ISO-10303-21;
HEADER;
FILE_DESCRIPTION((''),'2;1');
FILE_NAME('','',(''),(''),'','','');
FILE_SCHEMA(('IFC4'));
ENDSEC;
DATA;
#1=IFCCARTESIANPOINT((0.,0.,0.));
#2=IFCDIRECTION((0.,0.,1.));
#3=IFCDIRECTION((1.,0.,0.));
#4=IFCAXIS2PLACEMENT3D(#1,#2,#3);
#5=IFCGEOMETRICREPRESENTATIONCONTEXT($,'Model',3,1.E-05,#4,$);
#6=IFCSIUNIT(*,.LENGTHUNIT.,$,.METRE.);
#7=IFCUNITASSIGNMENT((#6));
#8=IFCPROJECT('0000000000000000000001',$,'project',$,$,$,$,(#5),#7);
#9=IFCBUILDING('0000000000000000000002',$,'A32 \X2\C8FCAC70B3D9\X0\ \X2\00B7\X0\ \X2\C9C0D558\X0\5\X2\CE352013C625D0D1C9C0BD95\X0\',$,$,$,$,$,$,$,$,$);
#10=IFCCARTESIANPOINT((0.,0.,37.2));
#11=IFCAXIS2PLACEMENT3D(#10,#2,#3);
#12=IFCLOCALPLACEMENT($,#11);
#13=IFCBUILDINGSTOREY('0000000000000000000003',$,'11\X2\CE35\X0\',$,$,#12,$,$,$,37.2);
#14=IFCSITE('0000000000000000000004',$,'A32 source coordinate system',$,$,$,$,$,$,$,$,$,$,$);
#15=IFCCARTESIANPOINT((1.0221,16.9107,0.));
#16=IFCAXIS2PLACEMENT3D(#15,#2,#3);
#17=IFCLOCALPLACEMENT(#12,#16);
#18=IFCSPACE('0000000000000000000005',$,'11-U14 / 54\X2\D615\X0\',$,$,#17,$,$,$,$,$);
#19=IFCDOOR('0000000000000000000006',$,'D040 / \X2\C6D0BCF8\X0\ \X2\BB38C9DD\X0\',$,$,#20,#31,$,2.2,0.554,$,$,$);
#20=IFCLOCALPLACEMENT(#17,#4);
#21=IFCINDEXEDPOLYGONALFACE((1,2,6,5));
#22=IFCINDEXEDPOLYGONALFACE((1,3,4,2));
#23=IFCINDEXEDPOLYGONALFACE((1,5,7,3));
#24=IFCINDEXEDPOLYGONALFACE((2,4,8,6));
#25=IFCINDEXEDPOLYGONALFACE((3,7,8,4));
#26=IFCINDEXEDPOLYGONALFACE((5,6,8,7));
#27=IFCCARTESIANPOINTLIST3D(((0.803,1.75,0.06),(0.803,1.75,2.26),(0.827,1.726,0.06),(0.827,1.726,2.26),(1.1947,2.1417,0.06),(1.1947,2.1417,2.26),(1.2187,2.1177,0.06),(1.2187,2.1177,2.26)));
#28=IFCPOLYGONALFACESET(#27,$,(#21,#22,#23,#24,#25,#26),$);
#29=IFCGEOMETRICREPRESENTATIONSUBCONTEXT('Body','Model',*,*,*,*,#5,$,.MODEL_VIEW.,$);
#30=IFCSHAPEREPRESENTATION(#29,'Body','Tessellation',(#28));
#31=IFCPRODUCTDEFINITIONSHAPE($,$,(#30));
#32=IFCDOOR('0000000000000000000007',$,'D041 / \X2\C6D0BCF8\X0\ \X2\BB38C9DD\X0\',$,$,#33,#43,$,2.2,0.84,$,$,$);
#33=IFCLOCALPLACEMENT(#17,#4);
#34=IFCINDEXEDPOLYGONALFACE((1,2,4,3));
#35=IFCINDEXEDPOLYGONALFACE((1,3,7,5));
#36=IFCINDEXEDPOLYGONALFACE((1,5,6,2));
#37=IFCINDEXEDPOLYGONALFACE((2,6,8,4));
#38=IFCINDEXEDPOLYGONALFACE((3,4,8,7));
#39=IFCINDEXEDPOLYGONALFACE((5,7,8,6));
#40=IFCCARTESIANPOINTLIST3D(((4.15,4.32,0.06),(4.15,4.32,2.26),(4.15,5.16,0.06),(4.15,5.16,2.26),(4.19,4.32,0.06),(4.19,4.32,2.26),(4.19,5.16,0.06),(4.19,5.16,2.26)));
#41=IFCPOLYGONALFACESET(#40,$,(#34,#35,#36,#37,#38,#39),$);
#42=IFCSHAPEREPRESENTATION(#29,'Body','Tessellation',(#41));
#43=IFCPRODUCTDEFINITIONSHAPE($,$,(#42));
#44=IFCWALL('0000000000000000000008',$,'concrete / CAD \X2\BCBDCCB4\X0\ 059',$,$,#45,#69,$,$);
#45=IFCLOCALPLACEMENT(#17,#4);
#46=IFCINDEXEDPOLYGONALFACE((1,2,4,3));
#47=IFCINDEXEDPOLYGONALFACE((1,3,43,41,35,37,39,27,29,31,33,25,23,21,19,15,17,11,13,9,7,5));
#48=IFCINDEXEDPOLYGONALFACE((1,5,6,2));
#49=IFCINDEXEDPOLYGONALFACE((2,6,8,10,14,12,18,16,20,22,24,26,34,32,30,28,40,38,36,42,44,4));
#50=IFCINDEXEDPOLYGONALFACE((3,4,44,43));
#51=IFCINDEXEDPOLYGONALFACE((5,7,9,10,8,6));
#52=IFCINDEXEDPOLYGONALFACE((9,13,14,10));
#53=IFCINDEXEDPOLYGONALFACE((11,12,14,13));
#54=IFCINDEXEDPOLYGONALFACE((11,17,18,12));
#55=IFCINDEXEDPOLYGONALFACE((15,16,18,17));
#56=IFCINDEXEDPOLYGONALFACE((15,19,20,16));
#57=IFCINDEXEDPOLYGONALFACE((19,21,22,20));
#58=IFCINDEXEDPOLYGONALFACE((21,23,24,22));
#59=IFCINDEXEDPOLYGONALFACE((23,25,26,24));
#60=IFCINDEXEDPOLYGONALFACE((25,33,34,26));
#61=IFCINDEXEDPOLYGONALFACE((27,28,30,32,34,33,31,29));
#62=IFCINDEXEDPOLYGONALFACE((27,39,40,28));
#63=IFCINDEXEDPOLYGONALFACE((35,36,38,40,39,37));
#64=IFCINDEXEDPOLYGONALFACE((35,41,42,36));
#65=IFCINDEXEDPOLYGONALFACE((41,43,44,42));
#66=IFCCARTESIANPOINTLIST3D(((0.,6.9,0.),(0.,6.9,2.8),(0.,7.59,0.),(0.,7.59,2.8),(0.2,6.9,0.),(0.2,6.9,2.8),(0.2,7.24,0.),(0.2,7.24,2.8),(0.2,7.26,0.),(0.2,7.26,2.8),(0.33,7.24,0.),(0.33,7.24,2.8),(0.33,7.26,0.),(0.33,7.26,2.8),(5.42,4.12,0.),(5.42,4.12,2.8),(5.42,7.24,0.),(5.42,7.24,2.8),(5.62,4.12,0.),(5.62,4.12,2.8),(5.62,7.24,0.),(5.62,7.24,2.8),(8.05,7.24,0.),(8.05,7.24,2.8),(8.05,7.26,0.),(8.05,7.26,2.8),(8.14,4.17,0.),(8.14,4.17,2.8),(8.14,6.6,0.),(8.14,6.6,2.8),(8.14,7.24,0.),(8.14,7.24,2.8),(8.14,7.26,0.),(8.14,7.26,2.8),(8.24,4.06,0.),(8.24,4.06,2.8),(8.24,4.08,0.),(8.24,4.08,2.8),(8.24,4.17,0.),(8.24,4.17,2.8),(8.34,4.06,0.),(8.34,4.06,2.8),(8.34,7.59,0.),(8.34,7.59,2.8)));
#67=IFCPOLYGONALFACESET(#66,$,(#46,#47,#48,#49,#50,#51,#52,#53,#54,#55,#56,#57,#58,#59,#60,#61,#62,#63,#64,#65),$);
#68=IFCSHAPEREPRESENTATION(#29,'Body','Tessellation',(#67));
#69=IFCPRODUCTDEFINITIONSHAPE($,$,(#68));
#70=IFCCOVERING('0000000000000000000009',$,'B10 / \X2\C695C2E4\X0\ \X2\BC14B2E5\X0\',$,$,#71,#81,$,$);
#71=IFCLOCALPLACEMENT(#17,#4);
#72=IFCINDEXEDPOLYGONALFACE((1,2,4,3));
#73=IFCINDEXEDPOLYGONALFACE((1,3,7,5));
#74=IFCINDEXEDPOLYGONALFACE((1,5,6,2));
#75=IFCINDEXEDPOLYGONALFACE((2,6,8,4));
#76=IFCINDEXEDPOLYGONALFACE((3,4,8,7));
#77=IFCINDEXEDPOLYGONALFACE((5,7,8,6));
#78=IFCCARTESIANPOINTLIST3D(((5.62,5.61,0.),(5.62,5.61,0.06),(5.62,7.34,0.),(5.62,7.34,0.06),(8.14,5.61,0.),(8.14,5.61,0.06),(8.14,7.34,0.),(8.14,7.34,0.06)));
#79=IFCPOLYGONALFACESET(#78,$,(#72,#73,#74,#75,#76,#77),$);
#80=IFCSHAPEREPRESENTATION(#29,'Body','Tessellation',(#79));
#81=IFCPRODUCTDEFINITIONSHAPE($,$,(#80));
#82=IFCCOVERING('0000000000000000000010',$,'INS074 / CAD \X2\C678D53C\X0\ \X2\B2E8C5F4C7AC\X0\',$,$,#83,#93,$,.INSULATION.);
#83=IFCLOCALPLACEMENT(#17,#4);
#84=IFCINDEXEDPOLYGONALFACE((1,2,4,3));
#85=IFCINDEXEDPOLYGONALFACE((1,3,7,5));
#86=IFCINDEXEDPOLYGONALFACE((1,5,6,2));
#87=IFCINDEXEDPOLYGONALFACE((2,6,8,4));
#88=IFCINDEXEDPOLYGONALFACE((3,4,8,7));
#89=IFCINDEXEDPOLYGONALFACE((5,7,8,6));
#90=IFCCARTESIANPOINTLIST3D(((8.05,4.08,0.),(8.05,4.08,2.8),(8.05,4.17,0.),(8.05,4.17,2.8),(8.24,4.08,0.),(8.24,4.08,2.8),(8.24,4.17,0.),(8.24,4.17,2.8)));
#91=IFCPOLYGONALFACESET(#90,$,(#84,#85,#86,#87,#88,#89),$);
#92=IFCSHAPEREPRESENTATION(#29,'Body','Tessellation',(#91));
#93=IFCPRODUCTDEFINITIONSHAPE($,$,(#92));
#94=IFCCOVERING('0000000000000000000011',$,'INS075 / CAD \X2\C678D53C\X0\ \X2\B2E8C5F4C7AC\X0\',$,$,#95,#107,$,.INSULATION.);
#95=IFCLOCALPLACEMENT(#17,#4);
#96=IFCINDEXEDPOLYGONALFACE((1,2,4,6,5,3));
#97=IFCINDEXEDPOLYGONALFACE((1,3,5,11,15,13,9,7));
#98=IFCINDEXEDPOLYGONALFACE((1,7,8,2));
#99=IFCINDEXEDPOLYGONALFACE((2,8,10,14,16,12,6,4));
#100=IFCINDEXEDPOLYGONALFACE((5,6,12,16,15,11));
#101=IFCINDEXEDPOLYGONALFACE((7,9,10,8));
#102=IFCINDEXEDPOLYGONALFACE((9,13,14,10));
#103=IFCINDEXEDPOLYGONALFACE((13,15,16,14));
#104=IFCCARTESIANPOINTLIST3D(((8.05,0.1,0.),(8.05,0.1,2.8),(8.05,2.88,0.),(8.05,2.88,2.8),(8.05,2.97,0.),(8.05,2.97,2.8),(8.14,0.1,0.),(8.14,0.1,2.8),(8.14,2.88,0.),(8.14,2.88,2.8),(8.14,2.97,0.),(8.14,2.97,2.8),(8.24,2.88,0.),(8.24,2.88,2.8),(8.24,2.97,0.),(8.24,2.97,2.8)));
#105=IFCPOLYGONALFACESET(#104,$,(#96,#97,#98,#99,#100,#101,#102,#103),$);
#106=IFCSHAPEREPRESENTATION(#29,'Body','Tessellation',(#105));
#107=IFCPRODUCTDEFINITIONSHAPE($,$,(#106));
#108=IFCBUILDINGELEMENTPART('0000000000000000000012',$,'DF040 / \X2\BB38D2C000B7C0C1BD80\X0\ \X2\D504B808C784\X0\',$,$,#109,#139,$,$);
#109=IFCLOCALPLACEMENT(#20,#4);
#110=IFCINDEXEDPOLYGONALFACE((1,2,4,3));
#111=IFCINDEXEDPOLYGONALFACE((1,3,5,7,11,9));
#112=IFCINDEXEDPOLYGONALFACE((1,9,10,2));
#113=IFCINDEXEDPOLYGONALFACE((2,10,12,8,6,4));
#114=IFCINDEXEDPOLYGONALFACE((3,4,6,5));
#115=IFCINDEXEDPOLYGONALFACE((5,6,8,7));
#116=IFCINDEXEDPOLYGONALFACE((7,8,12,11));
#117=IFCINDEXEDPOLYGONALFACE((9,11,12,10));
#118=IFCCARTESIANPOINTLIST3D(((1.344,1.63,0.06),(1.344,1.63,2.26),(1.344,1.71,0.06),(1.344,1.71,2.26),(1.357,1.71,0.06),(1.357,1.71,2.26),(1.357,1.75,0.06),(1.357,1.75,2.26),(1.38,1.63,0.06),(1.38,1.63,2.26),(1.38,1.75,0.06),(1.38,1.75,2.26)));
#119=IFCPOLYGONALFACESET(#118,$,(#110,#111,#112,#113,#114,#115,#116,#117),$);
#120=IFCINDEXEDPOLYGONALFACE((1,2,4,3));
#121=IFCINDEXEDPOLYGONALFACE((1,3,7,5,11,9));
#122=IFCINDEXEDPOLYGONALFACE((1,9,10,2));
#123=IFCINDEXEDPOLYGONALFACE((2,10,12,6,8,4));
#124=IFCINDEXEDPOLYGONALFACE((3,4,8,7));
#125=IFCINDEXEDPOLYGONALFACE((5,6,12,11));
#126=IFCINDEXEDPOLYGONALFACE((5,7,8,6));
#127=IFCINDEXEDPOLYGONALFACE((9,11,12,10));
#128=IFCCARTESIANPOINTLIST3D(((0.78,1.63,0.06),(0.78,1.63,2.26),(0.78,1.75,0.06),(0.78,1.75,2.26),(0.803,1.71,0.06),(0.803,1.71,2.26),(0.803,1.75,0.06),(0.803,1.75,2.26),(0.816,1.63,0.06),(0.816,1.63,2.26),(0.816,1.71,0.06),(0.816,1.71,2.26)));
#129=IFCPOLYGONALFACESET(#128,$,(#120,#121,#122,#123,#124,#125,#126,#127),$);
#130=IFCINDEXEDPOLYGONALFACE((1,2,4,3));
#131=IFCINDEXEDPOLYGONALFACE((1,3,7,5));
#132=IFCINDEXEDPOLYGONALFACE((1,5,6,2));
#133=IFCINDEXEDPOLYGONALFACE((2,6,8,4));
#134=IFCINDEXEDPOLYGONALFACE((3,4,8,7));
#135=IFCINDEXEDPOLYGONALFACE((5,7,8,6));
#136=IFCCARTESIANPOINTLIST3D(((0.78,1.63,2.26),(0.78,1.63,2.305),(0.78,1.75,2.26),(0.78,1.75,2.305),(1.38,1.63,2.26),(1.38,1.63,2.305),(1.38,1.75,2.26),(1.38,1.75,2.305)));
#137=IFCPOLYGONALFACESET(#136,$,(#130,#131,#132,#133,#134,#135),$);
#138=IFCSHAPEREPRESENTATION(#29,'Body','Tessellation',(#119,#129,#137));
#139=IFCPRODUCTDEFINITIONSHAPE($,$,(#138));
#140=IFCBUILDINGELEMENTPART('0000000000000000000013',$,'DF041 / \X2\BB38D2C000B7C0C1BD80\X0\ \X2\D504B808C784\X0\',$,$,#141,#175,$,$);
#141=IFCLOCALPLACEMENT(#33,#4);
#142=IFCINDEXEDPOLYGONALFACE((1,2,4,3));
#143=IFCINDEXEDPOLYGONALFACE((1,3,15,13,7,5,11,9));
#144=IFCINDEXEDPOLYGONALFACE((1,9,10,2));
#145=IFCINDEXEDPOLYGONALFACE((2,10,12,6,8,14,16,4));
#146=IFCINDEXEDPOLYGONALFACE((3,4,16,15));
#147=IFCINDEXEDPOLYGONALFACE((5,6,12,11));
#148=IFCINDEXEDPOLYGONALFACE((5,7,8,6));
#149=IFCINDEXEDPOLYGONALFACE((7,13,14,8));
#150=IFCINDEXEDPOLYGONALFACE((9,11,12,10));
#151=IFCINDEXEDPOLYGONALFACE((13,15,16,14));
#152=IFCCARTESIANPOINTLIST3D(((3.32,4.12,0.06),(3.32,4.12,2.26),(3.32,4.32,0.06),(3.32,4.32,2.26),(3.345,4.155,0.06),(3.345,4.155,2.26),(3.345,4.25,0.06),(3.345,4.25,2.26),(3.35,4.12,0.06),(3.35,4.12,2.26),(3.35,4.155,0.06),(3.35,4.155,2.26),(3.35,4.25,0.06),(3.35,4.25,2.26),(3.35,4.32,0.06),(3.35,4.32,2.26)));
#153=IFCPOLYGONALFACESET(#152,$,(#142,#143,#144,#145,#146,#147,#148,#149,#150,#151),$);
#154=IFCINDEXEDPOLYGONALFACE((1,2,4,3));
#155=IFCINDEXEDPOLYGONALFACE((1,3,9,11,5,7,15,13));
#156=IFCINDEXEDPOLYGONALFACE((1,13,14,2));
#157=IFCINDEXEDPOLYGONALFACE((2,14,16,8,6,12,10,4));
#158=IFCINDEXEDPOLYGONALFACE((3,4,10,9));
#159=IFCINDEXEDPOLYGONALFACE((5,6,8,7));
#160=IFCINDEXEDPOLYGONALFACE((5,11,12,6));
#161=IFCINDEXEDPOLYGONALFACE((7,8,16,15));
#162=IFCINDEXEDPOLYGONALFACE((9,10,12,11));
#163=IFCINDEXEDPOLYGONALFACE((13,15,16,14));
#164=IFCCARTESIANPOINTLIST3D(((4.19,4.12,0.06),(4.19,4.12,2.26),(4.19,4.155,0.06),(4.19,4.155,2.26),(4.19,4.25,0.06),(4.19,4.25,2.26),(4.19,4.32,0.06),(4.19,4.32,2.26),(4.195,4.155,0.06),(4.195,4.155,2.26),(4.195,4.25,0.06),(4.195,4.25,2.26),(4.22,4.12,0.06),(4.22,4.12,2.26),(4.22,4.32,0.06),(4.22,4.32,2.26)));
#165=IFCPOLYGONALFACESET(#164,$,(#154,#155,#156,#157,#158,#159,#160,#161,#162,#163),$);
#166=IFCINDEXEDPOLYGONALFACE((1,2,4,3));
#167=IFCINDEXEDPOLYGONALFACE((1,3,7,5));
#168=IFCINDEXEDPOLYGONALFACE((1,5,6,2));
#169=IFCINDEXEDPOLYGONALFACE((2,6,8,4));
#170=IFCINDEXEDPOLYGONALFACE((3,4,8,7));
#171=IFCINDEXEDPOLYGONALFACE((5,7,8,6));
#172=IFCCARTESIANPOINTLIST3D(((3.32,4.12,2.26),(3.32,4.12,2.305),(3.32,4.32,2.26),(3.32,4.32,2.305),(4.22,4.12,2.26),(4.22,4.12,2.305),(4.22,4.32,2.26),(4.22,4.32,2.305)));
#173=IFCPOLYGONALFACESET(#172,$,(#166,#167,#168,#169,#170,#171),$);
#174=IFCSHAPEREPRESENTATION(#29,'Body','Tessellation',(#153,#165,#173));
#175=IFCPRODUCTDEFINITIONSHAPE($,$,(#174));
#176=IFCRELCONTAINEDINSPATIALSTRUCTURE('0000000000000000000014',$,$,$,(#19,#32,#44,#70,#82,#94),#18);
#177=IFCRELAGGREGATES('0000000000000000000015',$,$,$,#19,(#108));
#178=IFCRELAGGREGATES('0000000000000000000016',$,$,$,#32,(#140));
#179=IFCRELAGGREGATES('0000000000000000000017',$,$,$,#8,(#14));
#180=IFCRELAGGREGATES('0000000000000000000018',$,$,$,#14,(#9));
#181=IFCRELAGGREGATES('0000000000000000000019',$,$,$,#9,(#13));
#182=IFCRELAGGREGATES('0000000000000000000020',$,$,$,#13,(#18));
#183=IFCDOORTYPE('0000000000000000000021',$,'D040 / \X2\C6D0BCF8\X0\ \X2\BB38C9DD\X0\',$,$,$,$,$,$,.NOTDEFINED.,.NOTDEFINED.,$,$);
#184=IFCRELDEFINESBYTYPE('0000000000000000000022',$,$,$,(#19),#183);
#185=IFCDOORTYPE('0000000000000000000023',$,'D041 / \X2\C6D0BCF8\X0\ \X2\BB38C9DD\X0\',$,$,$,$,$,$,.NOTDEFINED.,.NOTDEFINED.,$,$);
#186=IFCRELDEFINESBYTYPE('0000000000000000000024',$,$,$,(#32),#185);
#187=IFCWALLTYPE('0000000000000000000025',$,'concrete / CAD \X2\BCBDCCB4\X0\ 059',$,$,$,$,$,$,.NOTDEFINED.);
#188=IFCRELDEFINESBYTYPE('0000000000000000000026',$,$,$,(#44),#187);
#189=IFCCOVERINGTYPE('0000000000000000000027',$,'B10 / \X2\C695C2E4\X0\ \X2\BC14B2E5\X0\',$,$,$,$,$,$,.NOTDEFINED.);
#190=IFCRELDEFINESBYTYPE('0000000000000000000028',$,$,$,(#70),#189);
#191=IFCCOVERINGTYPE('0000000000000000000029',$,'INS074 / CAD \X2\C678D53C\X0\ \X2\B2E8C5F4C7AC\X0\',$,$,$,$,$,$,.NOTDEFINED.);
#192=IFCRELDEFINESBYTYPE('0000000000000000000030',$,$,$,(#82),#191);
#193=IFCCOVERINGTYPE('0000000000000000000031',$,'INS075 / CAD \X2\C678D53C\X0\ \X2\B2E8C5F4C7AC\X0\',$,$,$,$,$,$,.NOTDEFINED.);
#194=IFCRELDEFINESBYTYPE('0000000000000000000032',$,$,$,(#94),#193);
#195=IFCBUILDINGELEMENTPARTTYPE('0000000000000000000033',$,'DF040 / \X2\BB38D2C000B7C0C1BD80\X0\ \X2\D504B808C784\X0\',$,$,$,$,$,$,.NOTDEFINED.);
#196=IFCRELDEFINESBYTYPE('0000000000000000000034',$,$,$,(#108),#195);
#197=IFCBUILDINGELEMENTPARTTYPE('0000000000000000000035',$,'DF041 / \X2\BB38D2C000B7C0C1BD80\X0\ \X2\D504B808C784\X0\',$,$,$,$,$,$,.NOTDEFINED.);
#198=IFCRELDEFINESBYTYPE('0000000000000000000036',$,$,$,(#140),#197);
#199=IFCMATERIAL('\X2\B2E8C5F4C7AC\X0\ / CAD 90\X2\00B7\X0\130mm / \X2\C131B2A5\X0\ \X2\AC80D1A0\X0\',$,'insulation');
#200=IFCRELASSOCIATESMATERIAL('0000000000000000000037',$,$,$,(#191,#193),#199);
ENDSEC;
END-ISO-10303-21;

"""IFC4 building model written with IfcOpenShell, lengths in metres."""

from ifc_helpers import new_model, si_unit, frame, origin, origin_with_axes, place, context, subcontext, project, spatial, polyline, outline, extrude, source, transform, mapped, material, type_object, type_shapes, element, aggregate, save


model = new_model("IFC4")

# Units and contexts
model_context = context("Model", 3, precision=1e-05, world=origin_with_axes())
body_context = subcontext(model_context, "Body", "Model", "MODEL_VIEW")
ifc_project = project(units=[si_unit("LENGTHUNIT", "METRE")], contexts=[model_context])

# Site, building, storey, space
storey_placement = place(None, frame((0.0, 0.0, 37.2), z_axis=(0.0, 0.0, 1.0), x_axis=(1.0, 0.0, 0.0)))
space_1_placement = place(storey_placement, frame((1.0221, 16.9107, 0.0), z_axis=(0.0, 0.0, 1.0), x_axis=(1.0, 0.0, 0.0)))
site = spatial("IfcSite", under=ifc_project, Name="A32 source coordinate system")
building = spatial("IfcBuilding", under=site, Name="A32 주거동 · 지하5층–옥탑지붕")
storey = spatial("IfcBuildingStorey", under=building, at=storey_placement, Name="11층", Elevation=37.2)
space_1 = spatial("IfcSpace", under=storey, at=space_1_placement, Name="11-U14 / 54형")

# Doors
door_type_1 = type_object("IfcDoorType", Name="D040 / 원본 문짝", OperationType="NOTDEFINED", PredefinedType="NOTDEFINED")
shared_shape_1 = source(origin(), body_context, "Body", "SweptSolid", [
    extrude(outline(polyline([(0.803, 1.75), (1.1947, 2.1417), (1.2187, 2.1177), (0.827, 1.726), (0.803, 1.75)])), frame((0.0, 0.0, 0.06)), (0.0, 0.0, 1.0), 2.2),
])
type_shapes(door_type_1, [shared_shape_1])
door_1_placement = place(space_1_placement, origin_with_axes())
door_1 = element("IfcDoor", 1, at=door_1_placement, inside=space_1, type_object=door_type_1, Name="D040 / 원본 문짝", OverallHeight=2.2, OverallWidth=0.554, context=body_context, shape_type="MappedRepresentation", body=[
    mapped(shared_shape_1, transform((0.0, 0.0, 0.0), scale=1.0)),
])
door_type_2 = type_object("IfcDoorType", Name="D041 / 원본 문짝", OperationType="NOTDEFINED", PredefinedType="NOTDEFINED")
shared_shape_2 = source(origin(), body_context, "Body", "SweptSolid", [
    extrude(outline(polyline([(4.15, 5.16), (4.19, 5.16), (4.19, 4.32), (4.15, 4.32), (4.15, 5.16)])), frame((0.0, 0.0, 0.06)), (0.0, 0.0, 1.0), 2.2),
])
type_shapes(door_type_2, [shared_shape_2])
door_2_placement = place(space_1_placement, origin_with_axes())
door_2 = element("IfcDoor", 2, at=door_2_placement, inside=space_1, type_object=door_type_2, Name="D041 / 원본 문짝", OverallHeight=2.2, OverallWidth=0.84, context=body_context, shape_type="MappedRepresentation", body=[
    mapped(shared_shape_2, transform((0.0, 0.0, 0.0), scale=1.0)),
])

# Wall
wall_type_1 = type_object("IfcWallType", Name="concrete / CAD 벽체 059", PredefinedType="NOTDEFINED")
shared_shape_3 = source(origin(), body_context, "Body", "SweptSolid", [
    extrude(outline(polyline([(8.05, 7.26), (8.05, 7.24), (5.62, 7.24), (5.62, 4.12), (5.42, 4.12), (5.42, 7.24), (0.33, 7.24), (0.33, 7.26), (0.2, 7.26), (0.2, 7.24), (0.2, 6.9), (0.0, 6.9), (0.0, 7.59), (8.34, 7.59), (8.34, 4.06), (8.24, 4.06), (8.24, 4.08), (8.24, 4.17), (8.14, 4.17), (8.14, 6.6), (8.14, 7.24), (8.14, 7.26), (8.05, 7.26)])), origin(), (0.0, 0.0, 1.0), 2.8),
])
type_shapes(wall_type_1, [shared_shape_3])
wall_1_placement = place(space_1_placement, origin_with_axes())
element("IfcWall", 3, at=wall_1_placement, inside=space_1, type_object=wall_type_1, Name="concrete / CAD 벽체 059", context=body_context, shape_type="MappedRepresentation", body=[
    mapped(shared_shape_3, transform((0.0, 0.0, 0.0), scale=1.0)),
])

# Coverings
covering_type_1 = type_object("IfcCoveringType", Name="B10 / 욕실 바닥", PredefinedType="NOTDEFINED")
shared_shape_4 = source(origin(), body_context, "Body", "SweptSolid", [
    extrude(outline(polyline([(8.14, 5.61), (5.62, 5.61), (5.62, 7.34), (8.14, 7.34), (8.14, 5.61)])), origin(), (0.0, 0.0, 1.0), 0.06),
])
type_shapes(covering_type_1, [shared_shape_4])
covering_1_placement = place(space_1_placement, origin_with_axes())
element("IfcCovering", 4, at=covering_1_placement, inside=space_1, type_object=covering_type_1, Name="B10 / 욕실 바닥", context=body_context, shape_type="MappedRepresentation", body=[
    mapped(shared_shape_4, transform((0.0, 0.0, 0.0), scale=1.0)),
])
ifc_material = material(Name="단열재 / CAD 90·130mm / 성능 검토", Category="insulation")
covering_type_2 = type_object("IfcCoveringType", Name="INS074 / CAD 외피 단열재", PredefinedType="NOTDEFINED", material=ifc_material)
shared_shape_5 = source(origin(), body_context, "Body", "SweptSolid", [
    extrude(outline(polyline([(8.05, 4.08), (8.05, 4.17), (8.24, 4.17), (8.24, 4.08), (8.05, 4.08)])), origin(), (0.0, 0.0, 1.0), 2.8),
])
type_shapes(covering_type_2, [shared_shape_5])
covering_2_placement = place(space_1_placement, origin_with_axes())
element("IfcCovering", 5, at=covering_2_placement, inside=space_1, type_object=covering_type_2, Name="INS074 / CAD 외피 단열재", PredefinedType="INSULATION", context=body_context, shape_type="MappedRepresentation", body=[
    mapped(shared_shape_5, transform((0.0, 0.0, 0.0), scale=1.0)),
])
covering_type_3 = type_object("IfcCoveringType", Name="INS075 / CAD 외피 단열재", PredefinedType="NOTDEFINED", material=ifc_material)
shared_shape_6 = source(origin(), body_context, "Body", "SweptSolid", [
    extrude(outline(polyline([(8.24, 2.88), (8.14, 2.88), (8.14, 0.1), (8.05, 0.1), (8.05, 2.88), (8.05, 2.97), (8.14, 2.97), (8.24, 2.97), (8.24, 2.88)])), origin(), (0.0, 0.0, 1.0), 2.8),
])
type_shapes(covering_type_3, [shared_shape_6])
covering_3_placement = place(space_1_placement, origin_with_axes())
element("IfcCovering", 6, at=covering_3_placement, inside=space_1, type_object=covering_type_3, Name="INS075 / CAD 외피 단열재", PredefinedType="INSULATION", context=body_context, shape_type="MappedRepresentation", body=[
    mapped(shared_shape_6, transform((0.0, 0.0, 0.0), scale=1.0)),
])

# Building element parts
building_element_part_type_1 = type_object("IfcBuildingElementPartType", Name="DF040 / 문틀·상부 프레임", PredefinedType="NOTDEFINED")
shared_shape_7 = source(origin(), body_context, "Body", "SweptSolid", [
    extrude(outline(polyline([(1.344, 1.63), (1.344, 1.71), (1.357, 1.71), (1.357, 1.75), (1.38, 1.75), (1.38, 1.63), (1.344, 1.63)])), frame((0.0, 0.0, 0.06)), (0.0, 0.0, 1.0), 2.2),
    extrude(outline(polyline([(0.78, 1.75), (0.803, 1.75), (0.803, 1.71), (0.816, 1.71), (0.816, 1.63), (0.78, 1.63), (0.78, 1.75)])), frame((0.0, 0.0, 0.06)), (0.0, 0.0, 1.0), 2.2),
    extrude(outline(polyline([(0.78, 1.63), (0.78, 1.75), (1.38, 1.75), (1.38, 1.63), (0.78, 1.63)])), frame((0.0, 0.0, 2.26)), (0.0, 0.0, 1.0), 0.045),
])
type_shapes(building_element_part_type_1, [shared_shape_7])
building_element_part_1_placement = place(door_1_placement, origin_with_axes())
building_element_part_1 = element("IfcBuildingElementPart", 7, at=building_element_part_1_placement, type_object=building_element_part_type_1, Name="DF040 / 문틀·상부 프레임", context=body_context, shape_type="MappedRepresentation", body=[
    mapped(shared_shape_7, transform((0.0, 0.0, 0.0), scale=1.0)),
])
aggregate(door_1, [building_element_part_1])
building_element_part_type_2 = type_object("IfcBuildingElementPartType", Name="DF041 / 문틀·상부 프레임", PredefinedType="NOTDEFINED")
shared_shape_8 = source(origin(), body_context, "Body", "SweptSolid", [
    extrude(outline(polyline([(3.35, 4.32), (3.35, 4.25), (3.345, 4.25), (3.345, 4.155), (3.35, 4.155), (3.35, 4.12), (3.32, 4.12), (3.32, 4.32), (3.35, 4.32)])), frame((0.0, 0.0, 0.06)), (0.0, 0.0, 1.0), 2.2),
    extrude(outline(polyline([(4.22, 4.12), (4.19, 4.12), (4.19, 4.155), (4.195, 4.155), (4.195, 4.25), (4.19, 4.25), (4.19, 4.32), (4.22, 4.32), (4.22, 4.12)])), frame((0.0, 0.0, 0.06)), (0.0, 0.0, 1.0), 2.2),
    extrude(outline(polyline([(3.32, 4.12), (3.32, 4.32), (4.22, 4.32), (4.22, 4.12), (3.32, 4.12)])), frame((0.0, 0.0, 2.26)), (0.0, 0.0, 1.0), 0.045),
])
type_shapes(building_element_part_type_2, [shared_shape_8])
building_element_part_2_placement = place(door_2_placement, origin_with_axes())
building_element_part_2 = element("IfcBuildingElementPart", 8, at=building_element_part_2_placement, type_object=building_element_part_type_2, Name="DF041 / 문틀·상부 프레임", context=body_context, shape_type="MappedRepresentation", body=[
    mapped(shared_shape_8, transform((0.0, 0.0, 0.0), scale=1.0)),
])
aggregate(door_2, [building_element_part_2])

save(model, "model.ifc")
